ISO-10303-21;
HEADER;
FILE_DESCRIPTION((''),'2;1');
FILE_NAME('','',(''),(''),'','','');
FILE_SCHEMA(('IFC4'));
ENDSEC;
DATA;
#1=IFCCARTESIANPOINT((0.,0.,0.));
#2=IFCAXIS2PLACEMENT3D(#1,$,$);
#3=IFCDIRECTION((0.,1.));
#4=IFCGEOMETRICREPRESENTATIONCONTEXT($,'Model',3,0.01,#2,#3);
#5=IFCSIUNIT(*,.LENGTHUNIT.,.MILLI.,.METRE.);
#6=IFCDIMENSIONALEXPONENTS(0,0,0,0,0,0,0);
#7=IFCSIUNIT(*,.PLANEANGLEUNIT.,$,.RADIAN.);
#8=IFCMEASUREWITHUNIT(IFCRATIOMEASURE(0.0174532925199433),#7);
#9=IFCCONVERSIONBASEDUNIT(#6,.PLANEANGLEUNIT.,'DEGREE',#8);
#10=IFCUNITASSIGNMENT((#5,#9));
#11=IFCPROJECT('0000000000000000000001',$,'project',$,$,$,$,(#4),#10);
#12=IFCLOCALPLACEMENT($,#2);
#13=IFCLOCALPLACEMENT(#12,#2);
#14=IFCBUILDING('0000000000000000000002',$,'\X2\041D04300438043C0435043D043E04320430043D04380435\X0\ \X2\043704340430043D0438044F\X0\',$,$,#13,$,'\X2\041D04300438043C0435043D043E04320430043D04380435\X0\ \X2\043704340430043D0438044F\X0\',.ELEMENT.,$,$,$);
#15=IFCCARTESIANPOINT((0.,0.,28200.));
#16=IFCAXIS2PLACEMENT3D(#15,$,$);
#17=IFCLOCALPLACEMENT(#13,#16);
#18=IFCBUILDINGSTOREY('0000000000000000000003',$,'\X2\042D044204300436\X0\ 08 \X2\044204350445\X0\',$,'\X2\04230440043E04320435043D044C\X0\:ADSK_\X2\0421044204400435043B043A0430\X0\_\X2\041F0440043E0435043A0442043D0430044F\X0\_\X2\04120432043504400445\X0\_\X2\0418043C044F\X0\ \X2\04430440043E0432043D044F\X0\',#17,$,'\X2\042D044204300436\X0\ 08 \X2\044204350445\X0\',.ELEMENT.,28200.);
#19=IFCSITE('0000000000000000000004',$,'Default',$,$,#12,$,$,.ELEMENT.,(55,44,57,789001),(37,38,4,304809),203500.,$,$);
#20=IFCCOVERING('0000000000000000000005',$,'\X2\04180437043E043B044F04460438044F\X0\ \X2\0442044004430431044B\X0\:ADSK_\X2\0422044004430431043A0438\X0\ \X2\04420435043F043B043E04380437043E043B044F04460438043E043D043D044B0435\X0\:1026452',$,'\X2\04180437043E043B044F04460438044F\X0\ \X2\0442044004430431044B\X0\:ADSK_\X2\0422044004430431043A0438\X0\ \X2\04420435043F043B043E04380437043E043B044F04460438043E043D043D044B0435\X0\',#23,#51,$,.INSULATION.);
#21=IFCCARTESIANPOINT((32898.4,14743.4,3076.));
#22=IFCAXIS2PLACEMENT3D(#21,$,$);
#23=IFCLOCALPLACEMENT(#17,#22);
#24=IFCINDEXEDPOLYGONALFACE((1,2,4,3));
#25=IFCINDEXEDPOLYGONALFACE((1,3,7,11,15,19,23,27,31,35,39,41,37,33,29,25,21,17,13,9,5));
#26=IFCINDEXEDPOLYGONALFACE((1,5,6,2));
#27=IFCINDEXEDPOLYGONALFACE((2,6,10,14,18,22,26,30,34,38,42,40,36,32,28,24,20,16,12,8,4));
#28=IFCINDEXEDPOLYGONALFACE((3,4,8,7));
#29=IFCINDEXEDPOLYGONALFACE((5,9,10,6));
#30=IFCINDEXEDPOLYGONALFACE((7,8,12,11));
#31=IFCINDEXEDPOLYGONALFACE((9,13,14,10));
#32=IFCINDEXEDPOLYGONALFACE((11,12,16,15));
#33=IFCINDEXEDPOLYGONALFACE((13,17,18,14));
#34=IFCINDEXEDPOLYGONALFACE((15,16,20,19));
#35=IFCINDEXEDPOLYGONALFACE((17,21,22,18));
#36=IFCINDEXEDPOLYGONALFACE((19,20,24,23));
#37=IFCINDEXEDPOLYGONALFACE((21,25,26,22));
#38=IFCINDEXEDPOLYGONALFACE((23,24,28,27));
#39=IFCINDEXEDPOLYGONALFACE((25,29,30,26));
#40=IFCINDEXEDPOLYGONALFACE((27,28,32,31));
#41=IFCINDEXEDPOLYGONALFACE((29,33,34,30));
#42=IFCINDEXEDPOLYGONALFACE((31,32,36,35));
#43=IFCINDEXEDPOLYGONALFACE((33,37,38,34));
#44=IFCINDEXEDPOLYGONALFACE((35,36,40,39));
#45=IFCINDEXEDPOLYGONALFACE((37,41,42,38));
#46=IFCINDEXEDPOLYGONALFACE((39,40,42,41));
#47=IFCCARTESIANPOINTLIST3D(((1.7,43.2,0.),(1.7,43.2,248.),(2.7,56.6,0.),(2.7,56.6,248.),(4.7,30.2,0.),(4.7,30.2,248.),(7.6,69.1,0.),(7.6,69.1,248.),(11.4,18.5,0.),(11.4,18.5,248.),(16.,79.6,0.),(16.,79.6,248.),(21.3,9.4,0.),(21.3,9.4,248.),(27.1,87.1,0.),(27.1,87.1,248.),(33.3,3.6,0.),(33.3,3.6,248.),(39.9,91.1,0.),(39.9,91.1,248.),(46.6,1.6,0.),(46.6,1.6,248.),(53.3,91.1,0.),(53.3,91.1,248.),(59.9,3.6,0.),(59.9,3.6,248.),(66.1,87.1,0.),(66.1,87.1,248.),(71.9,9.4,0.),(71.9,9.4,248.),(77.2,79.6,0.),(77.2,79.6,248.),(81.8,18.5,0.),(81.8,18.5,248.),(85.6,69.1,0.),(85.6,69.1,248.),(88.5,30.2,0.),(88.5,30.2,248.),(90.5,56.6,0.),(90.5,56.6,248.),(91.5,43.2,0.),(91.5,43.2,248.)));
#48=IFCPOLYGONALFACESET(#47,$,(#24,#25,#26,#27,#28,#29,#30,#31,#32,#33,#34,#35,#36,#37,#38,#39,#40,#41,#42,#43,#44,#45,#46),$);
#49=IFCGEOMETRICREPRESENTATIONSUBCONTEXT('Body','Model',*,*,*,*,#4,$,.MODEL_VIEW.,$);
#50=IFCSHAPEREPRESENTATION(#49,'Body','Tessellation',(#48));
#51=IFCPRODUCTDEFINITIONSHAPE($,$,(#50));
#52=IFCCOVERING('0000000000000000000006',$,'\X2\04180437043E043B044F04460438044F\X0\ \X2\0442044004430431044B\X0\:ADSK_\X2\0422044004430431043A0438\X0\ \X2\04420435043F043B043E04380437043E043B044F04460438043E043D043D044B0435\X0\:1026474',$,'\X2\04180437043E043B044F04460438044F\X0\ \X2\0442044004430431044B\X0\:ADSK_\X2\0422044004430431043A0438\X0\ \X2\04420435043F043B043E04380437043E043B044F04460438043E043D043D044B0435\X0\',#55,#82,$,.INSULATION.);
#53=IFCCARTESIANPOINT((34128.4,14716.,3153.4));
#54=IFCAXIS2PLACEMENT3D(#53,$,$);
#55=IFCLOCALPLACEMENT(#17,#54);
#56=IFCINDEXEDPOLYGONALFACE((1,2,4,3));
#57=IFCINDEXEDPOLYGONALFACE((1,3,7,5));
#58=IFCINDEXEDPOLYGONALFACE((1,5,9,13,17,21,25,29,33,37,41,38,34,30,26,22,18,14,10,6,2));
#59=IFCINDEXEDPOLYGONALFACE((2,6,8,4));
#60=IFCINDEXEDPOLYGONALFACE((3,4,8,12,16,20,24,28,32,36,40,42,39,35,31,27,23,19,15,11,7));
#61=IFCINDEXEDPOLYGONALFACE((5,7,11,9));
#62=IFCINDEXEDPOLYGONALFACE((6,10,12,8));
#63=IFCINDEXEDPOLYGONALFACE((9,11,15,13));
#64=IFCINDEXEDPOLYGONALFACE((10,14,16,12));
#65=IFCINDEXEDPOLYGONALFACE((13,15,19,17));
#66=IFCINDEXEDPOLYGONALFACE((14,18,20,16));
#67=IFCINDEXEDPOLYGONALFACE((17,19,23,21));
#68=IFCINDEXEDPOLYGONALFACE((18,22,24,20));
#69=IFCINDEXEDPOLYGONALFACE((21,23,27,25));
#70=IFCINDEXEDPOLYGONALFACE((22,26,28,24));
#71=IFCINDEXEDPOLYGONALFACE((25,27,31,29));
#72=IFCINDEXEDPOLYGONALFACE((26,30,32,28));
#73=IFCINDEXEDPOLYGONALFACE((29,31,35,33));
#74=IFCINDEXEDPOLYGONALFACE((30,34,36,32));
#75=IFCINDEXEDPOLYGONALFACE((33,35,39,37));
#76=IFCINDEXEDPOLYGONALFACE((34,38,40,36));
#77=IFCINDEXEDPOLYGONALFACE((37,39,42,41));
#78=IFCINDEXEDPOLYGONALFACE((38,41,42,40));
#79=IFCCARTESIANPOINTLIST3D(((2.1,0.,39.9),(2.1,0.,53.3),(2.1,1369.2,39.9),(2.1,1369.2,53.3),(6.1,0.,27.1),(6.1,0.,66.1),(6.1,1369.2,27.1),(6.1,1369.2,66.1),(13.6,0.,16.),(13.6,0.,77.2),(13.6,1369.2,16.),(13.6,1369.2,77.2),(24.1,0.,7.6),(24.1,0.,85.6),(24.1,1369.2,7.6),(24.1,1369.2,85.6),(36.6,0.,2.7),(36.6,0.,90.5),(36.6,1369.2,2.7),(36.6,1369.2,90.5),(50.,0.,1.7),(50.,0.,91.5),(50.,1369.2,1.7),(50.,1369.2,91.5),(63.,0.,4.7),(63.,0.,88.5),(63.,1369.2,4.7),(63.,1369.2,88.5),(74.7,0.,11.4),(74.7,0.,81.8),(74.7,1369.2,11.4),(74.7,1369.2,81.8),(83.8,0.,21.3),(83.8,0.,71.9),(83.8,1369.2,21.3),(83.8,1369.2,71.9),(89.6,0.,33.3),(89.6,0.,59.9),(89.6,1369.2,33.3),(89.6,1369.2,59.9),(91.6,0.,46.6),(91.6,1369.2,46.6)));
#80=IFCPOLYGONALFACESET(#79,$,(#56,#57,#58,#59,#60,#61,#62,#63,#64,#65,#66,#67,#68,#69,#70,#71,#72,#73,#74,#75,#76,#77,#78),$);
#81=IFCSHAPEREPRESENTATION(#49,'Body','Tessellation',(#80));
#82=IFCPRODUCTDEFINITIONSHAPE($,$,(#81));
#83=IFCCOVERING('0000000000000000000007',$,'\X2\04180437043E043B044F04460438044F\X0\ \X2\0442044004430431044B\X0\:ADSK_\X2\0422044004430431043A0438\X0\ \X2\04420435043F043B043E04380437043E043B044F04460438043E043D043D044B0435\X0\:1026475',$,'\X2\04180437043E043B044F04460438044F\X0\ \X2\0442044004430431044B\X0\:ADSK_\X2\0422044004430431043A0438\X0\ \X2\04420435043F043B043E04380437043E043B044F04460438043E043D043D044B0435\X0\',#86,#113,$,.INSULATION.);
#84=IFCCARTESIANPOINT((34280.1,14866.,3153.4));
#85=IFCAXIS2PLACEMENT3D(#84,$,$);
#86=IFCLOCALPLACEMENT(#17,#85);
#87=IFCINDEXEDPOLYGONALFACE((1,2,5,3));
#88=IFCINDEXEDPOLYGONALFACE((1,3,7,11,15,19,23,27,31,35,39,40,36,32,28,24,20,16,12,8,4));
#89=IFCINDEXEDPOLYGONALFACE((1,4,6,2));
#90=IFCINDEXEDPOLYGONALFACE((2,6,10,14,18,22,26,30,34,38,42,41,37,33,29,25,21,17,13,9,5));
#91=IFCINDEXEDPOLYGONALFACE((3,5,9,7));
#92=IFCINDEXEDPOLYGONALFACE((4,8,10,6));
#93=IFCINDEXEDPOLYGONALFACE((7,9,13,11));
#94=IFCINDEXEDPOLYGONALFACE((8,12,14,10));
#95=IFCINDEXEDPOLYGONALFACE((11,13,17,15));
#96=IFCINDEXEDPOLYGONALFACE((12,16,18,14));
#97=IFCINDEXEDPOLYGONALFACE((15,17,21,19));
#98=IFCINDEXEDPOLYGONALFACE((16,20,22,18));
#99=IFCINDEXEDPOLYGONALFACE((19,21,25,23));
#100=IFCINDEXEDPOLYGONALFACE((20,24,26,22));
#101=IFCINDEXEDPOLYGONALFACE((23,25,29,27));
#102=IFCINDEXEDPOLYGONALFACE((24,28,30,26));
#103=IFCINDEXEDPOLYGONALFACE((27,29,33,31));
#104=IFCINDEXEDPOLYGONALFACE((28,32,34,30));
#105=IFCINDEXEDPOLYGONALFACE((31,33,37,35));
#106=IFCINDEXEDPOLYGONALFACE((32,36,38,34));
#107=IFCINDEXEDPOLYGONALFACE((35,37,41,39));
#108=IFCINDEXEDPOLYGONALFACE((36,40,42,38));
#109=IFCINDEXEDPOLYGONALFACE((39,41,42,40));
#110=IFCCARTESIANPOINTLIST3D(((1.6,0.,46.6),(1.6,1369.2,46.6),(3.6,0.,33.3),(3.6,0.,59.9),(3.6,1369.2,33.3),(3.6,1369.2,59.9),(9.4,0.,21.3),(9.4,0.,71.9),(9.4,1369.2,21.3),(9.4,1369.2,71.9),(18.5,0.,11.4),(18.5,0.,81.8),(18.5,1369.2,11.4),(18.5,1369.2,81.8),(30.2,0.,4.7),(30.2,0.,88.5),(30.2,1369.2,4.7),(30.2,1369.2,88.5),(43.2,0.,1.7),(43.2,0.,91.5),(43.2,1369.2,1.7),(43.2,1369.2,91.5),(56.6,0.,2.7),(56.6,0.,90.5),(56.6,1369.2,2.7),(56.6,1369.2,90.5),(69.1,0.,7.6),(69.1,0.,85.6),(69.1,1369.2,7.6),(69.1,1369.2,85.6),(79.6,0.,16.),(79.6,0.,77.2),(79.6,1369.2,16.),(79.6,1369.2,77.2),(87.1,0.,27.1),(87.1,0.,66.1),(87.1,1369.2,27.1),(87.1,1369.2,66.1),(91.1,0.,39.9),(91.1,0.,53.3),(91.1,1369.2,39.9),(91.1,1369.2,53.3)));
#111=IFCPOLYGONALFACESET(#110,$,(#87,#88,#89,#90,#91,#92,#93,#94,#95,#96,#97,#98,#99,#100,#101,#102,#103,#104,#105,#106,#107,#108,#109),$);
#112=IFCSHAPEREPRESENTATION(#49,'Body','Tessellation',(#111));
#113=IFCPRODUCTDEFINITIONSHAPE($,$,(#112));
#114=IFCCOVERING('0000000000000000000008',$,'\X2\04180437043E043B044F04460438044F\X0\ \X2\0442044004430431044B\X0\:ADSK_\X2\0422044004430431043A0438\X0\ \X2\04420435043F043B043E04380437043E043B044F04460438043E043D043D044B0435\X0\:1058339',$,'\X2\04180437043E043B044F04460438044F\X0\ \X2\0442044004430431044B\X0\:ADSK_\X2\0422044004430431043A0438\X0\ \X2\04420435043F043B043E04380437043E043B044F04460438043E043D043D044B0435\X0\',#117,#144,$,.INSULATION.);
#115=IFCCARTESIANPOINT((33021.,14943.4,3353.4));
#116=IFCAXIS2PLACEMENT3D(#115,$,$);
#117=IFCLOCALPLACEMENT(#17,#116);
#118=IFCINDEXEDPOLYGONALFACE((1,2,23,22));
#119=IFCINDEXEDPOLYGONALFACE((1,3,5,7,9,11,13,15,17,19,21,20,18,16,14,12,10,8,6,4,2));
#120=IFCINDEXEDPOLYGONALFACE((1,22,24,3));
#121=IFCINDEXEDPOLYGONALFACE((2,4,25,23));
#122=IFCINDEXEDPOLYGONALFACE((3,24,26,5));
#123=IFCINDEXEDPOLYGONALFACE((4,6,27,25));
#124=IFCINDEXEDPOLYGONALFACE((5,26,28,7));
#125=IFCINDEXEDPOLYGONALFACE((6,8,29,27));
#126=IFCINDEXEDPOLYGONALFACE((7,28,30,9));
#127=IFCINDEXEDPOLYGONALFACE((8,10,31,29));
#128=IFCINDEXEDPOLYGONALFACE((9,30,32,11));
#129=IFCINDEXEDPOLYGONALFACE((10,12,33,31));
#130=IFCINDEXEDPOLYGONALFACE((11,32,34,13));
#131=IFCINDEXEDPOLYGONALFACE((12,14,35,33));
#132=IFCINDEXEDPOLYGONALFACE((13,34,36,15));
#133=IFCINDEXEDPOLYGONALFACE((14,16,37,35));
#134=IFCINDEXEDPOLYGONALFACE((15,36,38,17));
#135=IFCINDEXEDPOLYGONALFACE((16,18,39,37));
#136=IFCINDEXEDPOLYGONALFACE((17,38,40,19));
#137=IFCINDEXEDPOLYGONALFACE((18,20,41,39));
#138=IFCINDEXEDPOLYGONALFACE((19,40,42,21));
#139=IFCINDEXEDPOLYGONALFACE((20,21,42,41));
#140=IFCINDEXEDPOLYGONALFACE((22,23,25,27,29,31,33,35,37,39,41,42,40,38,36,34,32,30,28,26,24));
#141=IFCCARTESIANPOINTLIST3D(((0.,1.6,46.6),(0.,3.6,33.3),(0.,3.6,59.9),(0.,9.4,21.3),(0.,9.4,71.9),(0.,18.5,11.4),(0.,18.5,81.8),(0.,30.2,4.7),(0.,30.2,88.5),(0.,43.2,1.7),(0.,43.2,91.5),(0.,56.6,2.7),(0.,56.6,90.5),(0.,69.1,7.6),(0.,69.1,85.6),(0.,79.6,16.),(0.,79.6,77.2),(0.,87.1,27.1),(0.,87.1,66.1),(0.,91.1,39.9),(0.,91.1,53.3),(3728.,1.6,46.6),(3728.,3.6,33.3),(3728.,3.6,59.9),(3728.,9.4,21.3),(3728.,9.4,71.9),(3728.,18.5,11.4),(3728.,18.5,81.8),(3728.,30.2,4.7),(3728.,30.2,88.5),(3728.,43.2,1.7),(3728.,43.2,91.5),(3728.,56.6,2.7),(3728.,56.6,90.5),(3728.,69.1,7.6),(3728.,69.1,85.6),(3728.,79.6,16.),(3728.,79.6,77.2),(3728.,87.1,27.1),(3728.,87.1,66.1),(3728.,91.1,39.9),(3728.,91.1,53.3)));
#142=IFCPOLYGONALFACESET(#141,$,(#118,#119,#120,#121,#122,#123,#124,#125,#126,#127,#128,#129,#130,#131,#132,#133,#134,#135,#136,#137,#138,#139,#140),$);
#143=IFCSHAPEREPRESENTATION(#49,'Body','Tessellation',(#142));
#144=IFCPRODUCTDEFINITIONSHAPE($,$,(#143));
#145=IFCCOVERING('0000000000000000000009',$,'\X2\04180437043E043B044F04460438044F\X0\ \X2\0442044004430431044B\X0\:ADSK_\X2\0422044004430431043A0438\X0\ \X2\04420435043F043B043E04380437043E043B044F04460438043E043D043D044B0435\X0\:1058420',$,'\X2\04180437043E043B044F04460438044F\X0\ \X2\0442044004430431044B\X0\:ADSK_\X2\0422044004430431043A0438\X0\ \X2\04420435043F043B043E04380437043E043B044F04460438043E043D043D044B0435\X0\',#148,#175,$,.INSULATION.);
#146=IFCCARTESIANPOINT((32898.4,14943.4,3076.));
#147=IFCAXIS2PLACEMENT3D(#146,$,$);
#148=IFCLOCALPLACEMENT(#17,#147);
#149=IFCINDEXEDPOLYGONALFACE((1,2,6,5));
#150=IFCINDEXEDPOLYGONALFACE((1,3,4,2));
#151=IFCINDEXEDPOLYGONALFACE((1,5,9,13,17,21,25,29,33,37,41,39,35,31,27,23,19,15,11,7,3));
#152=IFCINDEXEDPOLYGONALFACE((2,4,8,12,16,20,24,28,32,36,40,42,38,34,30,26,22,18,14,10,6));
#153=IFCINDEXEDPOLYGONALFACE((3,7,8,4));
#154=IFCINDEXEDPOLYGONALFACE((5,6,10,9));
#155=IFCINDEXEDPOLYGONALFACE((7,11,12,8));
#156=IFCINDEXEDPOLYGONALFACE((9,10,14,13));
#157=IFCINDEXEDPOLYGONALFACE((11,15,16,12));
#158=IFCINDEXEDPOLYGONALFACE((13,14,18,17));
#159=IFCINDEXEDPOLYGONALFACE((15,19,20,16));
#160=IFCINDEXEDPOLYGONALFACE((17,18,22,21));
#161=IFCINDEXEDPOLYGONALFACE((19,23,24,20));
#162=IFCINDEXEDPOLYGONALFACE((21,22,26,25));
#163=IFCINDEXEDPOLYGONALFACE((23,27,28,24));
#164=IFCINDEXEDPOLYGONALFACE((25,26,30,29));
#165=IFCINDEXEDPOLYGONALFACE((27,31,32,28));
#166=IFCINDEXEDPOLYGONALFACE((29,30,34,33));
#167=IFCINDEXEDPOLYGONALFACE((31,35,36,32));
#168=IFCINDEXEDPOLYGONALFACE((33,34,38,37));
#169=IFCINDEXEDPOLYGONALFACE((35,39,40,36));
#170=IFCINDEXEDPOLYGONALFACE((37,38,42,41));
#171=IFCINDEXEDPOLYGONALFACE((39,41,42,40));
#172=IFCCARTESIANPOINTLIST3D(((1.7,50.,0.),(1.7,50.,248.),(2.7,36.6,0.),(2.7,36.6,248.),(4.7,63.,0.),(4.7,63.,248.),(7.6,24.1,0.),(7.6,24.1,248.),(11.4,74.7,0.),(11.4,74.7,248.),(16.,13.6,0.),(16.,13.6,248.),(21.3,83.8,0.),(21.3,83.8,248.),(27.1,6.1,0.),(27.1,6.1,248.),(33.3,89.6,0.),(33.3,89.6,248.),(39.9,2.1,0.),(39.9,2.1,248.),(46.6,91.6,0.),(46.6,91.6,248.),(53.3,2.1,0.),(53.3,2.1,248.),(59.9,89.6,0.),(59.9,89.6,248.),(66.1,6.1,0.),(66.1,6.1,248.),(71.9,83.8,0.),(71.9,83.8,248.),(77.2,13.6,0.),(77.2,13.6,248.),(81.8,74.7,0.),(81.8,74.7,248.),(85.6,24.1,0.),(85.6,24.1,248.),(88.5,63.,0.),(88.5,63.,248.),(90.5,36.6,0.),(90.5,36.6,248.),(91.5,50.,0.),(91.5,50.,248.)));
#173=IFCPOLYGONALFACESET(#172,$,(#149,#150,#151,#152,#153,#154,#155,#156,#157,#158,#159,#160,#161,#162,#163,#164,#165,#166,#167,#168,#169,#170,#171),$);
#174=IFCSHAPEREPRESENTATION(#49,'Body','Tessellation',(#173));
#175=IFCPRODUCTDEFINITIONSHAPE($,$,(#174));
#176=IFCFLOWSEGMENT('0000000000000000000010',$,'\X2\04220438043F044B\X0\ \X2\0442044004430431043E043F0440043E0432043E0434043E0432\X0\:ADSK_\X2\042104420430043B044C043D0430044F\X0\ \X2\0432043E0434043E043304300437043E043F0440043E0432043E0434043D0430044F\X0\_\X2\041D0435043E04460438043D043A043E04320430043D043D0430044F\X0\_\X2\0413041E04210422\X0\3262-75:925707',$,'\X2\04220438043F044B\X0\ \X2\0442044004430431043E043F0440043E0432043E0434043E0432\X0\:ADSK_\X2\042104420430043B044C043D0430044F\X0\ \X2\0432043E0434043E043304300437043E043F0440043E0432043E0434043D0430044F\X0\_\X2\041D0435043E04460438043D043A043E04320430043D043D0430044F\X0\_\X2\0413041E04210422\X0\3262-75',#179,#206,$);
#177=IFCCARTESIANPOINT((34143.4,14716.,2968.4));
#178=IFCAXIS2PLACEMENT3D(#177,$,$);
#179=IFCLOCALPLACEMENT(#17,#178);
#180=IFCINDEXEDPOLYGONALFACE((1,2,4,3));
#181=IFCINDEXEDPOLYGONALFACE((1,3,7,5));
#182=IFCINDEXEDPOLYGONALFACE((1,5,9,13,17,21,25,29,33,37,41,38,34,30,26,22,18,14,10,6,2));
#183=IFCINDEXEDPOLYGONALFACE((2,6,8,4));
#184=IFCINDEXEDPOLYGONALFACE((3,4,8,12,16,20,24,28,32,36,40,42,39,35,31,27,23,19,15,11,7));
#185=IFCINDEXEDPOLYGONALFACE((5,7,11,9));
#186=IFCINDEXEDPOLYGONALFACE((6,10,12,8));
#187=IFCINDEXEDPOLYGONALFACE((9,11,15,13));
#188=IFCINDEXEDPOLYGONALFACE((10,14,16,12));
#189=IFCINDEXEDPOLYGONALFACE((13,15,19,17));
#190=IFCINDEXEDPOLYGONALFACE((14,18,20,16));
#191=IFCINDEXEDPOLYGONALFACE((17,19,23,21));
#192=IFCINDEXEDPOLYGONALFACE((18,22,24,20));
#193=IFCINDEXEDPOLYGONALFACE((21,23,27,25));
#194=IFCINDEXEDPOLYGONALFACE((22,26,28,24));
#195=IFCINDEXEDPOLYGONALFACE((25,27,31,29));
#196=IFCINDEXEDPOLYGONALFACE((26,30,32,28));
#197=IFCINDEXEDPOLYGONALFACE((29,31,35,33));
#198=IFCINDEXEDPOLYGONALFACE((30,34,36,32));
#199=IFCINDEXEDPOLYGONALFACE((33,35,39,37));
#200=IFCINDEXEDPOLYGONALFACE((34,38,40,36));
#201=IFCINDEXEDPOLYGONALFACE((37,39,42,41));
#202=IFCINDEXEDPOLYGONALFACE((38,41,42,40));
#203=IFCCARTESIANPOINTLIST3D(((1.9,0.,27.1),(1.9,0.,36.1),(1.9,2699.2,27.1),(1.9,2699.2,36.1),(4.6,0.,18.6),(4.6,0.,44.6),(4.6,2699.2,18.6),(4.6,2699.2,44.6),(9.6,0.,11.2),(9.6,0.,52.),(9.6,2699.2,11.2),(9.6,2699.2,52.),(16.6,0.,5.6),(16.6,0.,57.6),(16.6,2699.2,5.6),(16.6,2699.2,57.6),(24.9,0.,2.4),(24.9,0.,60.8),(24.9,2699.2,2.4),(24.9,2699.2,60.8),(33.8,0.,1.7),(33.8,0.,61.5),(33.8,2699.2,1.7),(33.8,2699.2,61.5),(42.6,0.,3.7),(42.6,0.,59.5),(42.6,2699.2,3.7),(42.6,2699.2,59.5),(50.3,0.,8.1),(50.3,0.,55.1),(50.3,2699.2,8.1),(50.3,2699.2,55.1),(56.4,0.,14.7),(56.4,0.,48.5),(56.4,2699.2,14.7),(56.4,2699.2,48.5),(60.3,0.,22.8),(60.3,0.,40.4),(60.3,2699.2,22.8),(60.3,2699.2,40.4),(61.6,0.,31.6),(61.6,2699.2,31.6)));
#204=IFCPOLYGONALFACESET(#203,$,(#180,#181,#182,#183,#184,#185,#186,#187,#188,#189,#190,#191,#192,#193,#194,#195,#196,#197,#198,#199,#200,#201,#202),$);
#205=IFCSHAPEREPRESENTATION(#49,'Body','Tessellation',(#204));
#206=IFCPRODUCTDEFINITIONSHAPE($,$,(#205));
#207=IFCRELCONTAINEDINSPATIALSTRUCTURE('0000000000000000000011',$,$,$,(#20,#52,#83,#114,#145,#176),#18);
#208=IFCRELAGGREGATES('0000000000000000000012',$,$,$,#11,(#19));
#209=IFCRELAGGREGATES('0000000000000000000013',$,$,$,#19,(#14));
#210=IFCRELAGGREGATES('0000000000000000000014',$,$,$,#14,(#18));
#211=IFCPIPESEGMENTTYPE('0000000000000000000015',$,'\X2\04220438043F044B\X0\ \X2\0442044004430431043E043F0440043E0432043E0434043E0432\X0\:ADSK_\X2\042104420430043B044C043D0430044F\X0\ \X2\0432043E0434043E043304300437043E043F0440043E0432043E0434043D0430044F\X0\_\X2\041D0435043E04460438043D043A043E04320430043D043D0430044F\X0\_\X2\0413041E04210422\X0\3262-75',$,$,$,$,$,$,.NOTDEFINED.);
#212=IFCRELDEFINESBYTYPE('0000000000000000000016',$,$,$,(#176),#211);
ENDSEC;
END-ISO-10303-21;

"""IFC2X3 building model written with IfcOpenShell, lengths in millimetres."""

from ifc_helpers import new_model, entity, si_unit, converted_unit, direction, frame, origin, origin_2d_with_axis, place, context, subcontext, project, spatial, circle, extrude, type_object, element, save


model = new_model("IFC2X3")

# Units and contexts
model_context = context("Model", 3, precision=0.01, world=origin(), true_north=direction((0.0, 1.0)))
body_context = subcontext(model_context, "Body", "Model", "MODEL_VIEW")
ifc_project = project(units=[si_unit("LENGTHUNIT", "METRE", prefix="MILLI"), converted_unit("PLANEANGLEUNIT", "DEGREE", entity("IfcRatioMeasure", 0.0174532925199433), si_unit("PLANEANGLEUNIT", "RADIAN"), dimensions=[0, 0, 0, 0, 0, 0, 0])], contexts=[model_context])

# Site, building, storey
site_placement = place(None, origin())
site = spatial("IfcSite", under=ifc_project, at=site_placement, Name="Default", CompositionType="ELEMENT", RefLatitude=(55, 44, 57, 789001), RefLongitude=(37, 38, 4, 304809), RefElevation=203500.0)
building_placement = place(site_placement, origin())
building = spatial("IfcBuilding", under=site, at=building_placement, Name="Наименование здания", LongName="Наименование здания", CompositionType="ELEMENT")
storey_placement = place(building_placement, frame((0.0, 0.0, 28200.0)))
storey = spatial("IfcBuildingStorey", under=building, at=storey_placement, Name="Этаж 08 тех", ObjectType="Уровень:ADSK_Стрелка_Проектная_Вверх_Имя уровня", LongName="Этаж 08 тех", CompositionType="ELEMENT", Elevation=28200.0)

# Coverings
covering_1_placement = place(storey_placement, frame((32898.4, 14743.4, 3076.0)))
element("IfcCovering", 1, at=covering_1_placement, inside=storey, Name="Изоляция трубы:ADSK_Трубки теплоизоляционные:1026452", ObjectType="Изоляция трубы:ADSK_Трубки теплоизоляционные", PredefinedType="INSULATION", context=body_context, shape_type="SweptSolid", body=[
    extrude(circle(Radius=45.0, at=origin_2d_with_axis()), frame((46.6, 46.6, 0.0), z_axis=(0.0, 0.0, 1.0), x_axis=(0.0, -1.0, 0.0)), (0.0, 0.0, 1.0), 248.0),
])
covering_2_placement = place(storey_placement, frame((34128.4, 14716.0, 3153.4)))
element("IfcCovering", 2, at=covering_2_placement, inside=storey, Name="Изоляция трубы:ADSK_Трубки теплоизоляционные:1026474", ObjectType="Изоляция трубы:ADSK_Трубки теплоизоляционные", PredefinedType="INSULATION", context=body_context, shape_type="SweptSolid", body=[
    extrude(circle(Radius=45.0, at=origin_2d_with_axis()), frame((46.6, 0.0, 46.6), z_axis=(0.0, 1.0, 0.0), x_axis=(1.0, 0.0, 0.0)), (0.0, 0.0, 1.0), 1369.2),
])
covering_3_placement = place(storey_placement, frame((34280.1, 14866.0, 3153.4)))
element("IfcCovering", 3, at=covering_3_placement, inside=storey, Name="Изоляция трубы:ADSK_Трубки теплоизоляционные:1026475", ObjectType="Изоляция трубы:ADSK_Трубки теплоизоляционные", PredefinedType="INSULATION", context=body_context, shape_type="SweptSolid", body=[
    extrude(circle(Radius=45.0, at=origin_2d_with_axis()), frame((46.6, 0.0, 46.6), z_axis=(0.0, 1.0, 0.0), x_axis=(-1.0, 0.0, 0.0)), (0.0, 0.0, 1.0), 1369.2),
])
covering_4_placement = place(storey_placement, frame((33021.0, 14943.4, 3353.4)))
element("IfcCovering", 4, at=covering_4_placement, inside=storey, Name="Изоляция трубы:ADSK_Трубки теплоизоляционные:1058339", ObjectType="Изоляция трубы:ADSK_Трубки теплоизоляционные", PredefinedType="INSULATION", context=body_context, shape_type="SweptSolid", body=[
    extrude(circle(Radius=45.0, at=origin_2d_with_axis()), frame((0.0, 46.6, 46.6), z_axis=(1.0, 0.0, 0.0), x_axis=(0.0, -1.0, 0.0)), (0.0, 0.0, 1.0), 3728.0),
])
covering_5_placement = place(storey_placement, frame((32898.4, 14943.4, 3076.0)))
element("IfcCovering", 5, at=covering_5_placement, inside=storey, Name="Изоляция трубы:ADSK_Трубки теплоизоляционные:1058420", ObjectType="Изоляция трубы:ADSK_Трубки теплоизоляционные", PredefinedType="INSULATION", context=body_context, shape_type="SweptSolid", body=[
    extrude(circle(Radius=45.0, at=origin_2d_with_axis()), frame((46.6, 46.6, 0.0), z_axis=(0.0, 0.0, 1.0), x_axis=(0.0, 1.0, 0.0)), (0.0, 0.0, 1.0), 248.0),
])

# Flow segment
pipe_segment_type = type_object("IfcPipeSegmentType", Name="Типы трубопроводов:ADSK_Стальная водогазопроводная_Неоцинкованная_ГОСТ3262-75", PredefinedType="NOTDEFINED")
flow_segment_1_placement = place(storey_placement, frame((34143.4, 14716.0, 2968.4)))
element("IfcFlowSegment", 6, at=flow_segment_1_placement, inside=storey, type_object=pipe_segment_type, Name="Типы трубопроводов:ADSK_Стальная водогазопроводная_Неоцинкованная_ГОСТ3262-75:925707", ObjectType="Типы трубопроводов:ADSK_Стальная водогазопроводная_Неоцинкованная_ГОСТ3262-75", context=body_context, shape_type="SweptSolid", body=[
    extrude(circle(Radius=30.0, at=origin_2d_with_axis()), frame((31.6, 0.0, 31.6), z_axis=(0.0, 1.0, 0.0), x_axis=(1.0, 0.0, 0.0)), (0.0, 0.0, 1.0), 2699.2),
])

save(model, "model.ifc")
